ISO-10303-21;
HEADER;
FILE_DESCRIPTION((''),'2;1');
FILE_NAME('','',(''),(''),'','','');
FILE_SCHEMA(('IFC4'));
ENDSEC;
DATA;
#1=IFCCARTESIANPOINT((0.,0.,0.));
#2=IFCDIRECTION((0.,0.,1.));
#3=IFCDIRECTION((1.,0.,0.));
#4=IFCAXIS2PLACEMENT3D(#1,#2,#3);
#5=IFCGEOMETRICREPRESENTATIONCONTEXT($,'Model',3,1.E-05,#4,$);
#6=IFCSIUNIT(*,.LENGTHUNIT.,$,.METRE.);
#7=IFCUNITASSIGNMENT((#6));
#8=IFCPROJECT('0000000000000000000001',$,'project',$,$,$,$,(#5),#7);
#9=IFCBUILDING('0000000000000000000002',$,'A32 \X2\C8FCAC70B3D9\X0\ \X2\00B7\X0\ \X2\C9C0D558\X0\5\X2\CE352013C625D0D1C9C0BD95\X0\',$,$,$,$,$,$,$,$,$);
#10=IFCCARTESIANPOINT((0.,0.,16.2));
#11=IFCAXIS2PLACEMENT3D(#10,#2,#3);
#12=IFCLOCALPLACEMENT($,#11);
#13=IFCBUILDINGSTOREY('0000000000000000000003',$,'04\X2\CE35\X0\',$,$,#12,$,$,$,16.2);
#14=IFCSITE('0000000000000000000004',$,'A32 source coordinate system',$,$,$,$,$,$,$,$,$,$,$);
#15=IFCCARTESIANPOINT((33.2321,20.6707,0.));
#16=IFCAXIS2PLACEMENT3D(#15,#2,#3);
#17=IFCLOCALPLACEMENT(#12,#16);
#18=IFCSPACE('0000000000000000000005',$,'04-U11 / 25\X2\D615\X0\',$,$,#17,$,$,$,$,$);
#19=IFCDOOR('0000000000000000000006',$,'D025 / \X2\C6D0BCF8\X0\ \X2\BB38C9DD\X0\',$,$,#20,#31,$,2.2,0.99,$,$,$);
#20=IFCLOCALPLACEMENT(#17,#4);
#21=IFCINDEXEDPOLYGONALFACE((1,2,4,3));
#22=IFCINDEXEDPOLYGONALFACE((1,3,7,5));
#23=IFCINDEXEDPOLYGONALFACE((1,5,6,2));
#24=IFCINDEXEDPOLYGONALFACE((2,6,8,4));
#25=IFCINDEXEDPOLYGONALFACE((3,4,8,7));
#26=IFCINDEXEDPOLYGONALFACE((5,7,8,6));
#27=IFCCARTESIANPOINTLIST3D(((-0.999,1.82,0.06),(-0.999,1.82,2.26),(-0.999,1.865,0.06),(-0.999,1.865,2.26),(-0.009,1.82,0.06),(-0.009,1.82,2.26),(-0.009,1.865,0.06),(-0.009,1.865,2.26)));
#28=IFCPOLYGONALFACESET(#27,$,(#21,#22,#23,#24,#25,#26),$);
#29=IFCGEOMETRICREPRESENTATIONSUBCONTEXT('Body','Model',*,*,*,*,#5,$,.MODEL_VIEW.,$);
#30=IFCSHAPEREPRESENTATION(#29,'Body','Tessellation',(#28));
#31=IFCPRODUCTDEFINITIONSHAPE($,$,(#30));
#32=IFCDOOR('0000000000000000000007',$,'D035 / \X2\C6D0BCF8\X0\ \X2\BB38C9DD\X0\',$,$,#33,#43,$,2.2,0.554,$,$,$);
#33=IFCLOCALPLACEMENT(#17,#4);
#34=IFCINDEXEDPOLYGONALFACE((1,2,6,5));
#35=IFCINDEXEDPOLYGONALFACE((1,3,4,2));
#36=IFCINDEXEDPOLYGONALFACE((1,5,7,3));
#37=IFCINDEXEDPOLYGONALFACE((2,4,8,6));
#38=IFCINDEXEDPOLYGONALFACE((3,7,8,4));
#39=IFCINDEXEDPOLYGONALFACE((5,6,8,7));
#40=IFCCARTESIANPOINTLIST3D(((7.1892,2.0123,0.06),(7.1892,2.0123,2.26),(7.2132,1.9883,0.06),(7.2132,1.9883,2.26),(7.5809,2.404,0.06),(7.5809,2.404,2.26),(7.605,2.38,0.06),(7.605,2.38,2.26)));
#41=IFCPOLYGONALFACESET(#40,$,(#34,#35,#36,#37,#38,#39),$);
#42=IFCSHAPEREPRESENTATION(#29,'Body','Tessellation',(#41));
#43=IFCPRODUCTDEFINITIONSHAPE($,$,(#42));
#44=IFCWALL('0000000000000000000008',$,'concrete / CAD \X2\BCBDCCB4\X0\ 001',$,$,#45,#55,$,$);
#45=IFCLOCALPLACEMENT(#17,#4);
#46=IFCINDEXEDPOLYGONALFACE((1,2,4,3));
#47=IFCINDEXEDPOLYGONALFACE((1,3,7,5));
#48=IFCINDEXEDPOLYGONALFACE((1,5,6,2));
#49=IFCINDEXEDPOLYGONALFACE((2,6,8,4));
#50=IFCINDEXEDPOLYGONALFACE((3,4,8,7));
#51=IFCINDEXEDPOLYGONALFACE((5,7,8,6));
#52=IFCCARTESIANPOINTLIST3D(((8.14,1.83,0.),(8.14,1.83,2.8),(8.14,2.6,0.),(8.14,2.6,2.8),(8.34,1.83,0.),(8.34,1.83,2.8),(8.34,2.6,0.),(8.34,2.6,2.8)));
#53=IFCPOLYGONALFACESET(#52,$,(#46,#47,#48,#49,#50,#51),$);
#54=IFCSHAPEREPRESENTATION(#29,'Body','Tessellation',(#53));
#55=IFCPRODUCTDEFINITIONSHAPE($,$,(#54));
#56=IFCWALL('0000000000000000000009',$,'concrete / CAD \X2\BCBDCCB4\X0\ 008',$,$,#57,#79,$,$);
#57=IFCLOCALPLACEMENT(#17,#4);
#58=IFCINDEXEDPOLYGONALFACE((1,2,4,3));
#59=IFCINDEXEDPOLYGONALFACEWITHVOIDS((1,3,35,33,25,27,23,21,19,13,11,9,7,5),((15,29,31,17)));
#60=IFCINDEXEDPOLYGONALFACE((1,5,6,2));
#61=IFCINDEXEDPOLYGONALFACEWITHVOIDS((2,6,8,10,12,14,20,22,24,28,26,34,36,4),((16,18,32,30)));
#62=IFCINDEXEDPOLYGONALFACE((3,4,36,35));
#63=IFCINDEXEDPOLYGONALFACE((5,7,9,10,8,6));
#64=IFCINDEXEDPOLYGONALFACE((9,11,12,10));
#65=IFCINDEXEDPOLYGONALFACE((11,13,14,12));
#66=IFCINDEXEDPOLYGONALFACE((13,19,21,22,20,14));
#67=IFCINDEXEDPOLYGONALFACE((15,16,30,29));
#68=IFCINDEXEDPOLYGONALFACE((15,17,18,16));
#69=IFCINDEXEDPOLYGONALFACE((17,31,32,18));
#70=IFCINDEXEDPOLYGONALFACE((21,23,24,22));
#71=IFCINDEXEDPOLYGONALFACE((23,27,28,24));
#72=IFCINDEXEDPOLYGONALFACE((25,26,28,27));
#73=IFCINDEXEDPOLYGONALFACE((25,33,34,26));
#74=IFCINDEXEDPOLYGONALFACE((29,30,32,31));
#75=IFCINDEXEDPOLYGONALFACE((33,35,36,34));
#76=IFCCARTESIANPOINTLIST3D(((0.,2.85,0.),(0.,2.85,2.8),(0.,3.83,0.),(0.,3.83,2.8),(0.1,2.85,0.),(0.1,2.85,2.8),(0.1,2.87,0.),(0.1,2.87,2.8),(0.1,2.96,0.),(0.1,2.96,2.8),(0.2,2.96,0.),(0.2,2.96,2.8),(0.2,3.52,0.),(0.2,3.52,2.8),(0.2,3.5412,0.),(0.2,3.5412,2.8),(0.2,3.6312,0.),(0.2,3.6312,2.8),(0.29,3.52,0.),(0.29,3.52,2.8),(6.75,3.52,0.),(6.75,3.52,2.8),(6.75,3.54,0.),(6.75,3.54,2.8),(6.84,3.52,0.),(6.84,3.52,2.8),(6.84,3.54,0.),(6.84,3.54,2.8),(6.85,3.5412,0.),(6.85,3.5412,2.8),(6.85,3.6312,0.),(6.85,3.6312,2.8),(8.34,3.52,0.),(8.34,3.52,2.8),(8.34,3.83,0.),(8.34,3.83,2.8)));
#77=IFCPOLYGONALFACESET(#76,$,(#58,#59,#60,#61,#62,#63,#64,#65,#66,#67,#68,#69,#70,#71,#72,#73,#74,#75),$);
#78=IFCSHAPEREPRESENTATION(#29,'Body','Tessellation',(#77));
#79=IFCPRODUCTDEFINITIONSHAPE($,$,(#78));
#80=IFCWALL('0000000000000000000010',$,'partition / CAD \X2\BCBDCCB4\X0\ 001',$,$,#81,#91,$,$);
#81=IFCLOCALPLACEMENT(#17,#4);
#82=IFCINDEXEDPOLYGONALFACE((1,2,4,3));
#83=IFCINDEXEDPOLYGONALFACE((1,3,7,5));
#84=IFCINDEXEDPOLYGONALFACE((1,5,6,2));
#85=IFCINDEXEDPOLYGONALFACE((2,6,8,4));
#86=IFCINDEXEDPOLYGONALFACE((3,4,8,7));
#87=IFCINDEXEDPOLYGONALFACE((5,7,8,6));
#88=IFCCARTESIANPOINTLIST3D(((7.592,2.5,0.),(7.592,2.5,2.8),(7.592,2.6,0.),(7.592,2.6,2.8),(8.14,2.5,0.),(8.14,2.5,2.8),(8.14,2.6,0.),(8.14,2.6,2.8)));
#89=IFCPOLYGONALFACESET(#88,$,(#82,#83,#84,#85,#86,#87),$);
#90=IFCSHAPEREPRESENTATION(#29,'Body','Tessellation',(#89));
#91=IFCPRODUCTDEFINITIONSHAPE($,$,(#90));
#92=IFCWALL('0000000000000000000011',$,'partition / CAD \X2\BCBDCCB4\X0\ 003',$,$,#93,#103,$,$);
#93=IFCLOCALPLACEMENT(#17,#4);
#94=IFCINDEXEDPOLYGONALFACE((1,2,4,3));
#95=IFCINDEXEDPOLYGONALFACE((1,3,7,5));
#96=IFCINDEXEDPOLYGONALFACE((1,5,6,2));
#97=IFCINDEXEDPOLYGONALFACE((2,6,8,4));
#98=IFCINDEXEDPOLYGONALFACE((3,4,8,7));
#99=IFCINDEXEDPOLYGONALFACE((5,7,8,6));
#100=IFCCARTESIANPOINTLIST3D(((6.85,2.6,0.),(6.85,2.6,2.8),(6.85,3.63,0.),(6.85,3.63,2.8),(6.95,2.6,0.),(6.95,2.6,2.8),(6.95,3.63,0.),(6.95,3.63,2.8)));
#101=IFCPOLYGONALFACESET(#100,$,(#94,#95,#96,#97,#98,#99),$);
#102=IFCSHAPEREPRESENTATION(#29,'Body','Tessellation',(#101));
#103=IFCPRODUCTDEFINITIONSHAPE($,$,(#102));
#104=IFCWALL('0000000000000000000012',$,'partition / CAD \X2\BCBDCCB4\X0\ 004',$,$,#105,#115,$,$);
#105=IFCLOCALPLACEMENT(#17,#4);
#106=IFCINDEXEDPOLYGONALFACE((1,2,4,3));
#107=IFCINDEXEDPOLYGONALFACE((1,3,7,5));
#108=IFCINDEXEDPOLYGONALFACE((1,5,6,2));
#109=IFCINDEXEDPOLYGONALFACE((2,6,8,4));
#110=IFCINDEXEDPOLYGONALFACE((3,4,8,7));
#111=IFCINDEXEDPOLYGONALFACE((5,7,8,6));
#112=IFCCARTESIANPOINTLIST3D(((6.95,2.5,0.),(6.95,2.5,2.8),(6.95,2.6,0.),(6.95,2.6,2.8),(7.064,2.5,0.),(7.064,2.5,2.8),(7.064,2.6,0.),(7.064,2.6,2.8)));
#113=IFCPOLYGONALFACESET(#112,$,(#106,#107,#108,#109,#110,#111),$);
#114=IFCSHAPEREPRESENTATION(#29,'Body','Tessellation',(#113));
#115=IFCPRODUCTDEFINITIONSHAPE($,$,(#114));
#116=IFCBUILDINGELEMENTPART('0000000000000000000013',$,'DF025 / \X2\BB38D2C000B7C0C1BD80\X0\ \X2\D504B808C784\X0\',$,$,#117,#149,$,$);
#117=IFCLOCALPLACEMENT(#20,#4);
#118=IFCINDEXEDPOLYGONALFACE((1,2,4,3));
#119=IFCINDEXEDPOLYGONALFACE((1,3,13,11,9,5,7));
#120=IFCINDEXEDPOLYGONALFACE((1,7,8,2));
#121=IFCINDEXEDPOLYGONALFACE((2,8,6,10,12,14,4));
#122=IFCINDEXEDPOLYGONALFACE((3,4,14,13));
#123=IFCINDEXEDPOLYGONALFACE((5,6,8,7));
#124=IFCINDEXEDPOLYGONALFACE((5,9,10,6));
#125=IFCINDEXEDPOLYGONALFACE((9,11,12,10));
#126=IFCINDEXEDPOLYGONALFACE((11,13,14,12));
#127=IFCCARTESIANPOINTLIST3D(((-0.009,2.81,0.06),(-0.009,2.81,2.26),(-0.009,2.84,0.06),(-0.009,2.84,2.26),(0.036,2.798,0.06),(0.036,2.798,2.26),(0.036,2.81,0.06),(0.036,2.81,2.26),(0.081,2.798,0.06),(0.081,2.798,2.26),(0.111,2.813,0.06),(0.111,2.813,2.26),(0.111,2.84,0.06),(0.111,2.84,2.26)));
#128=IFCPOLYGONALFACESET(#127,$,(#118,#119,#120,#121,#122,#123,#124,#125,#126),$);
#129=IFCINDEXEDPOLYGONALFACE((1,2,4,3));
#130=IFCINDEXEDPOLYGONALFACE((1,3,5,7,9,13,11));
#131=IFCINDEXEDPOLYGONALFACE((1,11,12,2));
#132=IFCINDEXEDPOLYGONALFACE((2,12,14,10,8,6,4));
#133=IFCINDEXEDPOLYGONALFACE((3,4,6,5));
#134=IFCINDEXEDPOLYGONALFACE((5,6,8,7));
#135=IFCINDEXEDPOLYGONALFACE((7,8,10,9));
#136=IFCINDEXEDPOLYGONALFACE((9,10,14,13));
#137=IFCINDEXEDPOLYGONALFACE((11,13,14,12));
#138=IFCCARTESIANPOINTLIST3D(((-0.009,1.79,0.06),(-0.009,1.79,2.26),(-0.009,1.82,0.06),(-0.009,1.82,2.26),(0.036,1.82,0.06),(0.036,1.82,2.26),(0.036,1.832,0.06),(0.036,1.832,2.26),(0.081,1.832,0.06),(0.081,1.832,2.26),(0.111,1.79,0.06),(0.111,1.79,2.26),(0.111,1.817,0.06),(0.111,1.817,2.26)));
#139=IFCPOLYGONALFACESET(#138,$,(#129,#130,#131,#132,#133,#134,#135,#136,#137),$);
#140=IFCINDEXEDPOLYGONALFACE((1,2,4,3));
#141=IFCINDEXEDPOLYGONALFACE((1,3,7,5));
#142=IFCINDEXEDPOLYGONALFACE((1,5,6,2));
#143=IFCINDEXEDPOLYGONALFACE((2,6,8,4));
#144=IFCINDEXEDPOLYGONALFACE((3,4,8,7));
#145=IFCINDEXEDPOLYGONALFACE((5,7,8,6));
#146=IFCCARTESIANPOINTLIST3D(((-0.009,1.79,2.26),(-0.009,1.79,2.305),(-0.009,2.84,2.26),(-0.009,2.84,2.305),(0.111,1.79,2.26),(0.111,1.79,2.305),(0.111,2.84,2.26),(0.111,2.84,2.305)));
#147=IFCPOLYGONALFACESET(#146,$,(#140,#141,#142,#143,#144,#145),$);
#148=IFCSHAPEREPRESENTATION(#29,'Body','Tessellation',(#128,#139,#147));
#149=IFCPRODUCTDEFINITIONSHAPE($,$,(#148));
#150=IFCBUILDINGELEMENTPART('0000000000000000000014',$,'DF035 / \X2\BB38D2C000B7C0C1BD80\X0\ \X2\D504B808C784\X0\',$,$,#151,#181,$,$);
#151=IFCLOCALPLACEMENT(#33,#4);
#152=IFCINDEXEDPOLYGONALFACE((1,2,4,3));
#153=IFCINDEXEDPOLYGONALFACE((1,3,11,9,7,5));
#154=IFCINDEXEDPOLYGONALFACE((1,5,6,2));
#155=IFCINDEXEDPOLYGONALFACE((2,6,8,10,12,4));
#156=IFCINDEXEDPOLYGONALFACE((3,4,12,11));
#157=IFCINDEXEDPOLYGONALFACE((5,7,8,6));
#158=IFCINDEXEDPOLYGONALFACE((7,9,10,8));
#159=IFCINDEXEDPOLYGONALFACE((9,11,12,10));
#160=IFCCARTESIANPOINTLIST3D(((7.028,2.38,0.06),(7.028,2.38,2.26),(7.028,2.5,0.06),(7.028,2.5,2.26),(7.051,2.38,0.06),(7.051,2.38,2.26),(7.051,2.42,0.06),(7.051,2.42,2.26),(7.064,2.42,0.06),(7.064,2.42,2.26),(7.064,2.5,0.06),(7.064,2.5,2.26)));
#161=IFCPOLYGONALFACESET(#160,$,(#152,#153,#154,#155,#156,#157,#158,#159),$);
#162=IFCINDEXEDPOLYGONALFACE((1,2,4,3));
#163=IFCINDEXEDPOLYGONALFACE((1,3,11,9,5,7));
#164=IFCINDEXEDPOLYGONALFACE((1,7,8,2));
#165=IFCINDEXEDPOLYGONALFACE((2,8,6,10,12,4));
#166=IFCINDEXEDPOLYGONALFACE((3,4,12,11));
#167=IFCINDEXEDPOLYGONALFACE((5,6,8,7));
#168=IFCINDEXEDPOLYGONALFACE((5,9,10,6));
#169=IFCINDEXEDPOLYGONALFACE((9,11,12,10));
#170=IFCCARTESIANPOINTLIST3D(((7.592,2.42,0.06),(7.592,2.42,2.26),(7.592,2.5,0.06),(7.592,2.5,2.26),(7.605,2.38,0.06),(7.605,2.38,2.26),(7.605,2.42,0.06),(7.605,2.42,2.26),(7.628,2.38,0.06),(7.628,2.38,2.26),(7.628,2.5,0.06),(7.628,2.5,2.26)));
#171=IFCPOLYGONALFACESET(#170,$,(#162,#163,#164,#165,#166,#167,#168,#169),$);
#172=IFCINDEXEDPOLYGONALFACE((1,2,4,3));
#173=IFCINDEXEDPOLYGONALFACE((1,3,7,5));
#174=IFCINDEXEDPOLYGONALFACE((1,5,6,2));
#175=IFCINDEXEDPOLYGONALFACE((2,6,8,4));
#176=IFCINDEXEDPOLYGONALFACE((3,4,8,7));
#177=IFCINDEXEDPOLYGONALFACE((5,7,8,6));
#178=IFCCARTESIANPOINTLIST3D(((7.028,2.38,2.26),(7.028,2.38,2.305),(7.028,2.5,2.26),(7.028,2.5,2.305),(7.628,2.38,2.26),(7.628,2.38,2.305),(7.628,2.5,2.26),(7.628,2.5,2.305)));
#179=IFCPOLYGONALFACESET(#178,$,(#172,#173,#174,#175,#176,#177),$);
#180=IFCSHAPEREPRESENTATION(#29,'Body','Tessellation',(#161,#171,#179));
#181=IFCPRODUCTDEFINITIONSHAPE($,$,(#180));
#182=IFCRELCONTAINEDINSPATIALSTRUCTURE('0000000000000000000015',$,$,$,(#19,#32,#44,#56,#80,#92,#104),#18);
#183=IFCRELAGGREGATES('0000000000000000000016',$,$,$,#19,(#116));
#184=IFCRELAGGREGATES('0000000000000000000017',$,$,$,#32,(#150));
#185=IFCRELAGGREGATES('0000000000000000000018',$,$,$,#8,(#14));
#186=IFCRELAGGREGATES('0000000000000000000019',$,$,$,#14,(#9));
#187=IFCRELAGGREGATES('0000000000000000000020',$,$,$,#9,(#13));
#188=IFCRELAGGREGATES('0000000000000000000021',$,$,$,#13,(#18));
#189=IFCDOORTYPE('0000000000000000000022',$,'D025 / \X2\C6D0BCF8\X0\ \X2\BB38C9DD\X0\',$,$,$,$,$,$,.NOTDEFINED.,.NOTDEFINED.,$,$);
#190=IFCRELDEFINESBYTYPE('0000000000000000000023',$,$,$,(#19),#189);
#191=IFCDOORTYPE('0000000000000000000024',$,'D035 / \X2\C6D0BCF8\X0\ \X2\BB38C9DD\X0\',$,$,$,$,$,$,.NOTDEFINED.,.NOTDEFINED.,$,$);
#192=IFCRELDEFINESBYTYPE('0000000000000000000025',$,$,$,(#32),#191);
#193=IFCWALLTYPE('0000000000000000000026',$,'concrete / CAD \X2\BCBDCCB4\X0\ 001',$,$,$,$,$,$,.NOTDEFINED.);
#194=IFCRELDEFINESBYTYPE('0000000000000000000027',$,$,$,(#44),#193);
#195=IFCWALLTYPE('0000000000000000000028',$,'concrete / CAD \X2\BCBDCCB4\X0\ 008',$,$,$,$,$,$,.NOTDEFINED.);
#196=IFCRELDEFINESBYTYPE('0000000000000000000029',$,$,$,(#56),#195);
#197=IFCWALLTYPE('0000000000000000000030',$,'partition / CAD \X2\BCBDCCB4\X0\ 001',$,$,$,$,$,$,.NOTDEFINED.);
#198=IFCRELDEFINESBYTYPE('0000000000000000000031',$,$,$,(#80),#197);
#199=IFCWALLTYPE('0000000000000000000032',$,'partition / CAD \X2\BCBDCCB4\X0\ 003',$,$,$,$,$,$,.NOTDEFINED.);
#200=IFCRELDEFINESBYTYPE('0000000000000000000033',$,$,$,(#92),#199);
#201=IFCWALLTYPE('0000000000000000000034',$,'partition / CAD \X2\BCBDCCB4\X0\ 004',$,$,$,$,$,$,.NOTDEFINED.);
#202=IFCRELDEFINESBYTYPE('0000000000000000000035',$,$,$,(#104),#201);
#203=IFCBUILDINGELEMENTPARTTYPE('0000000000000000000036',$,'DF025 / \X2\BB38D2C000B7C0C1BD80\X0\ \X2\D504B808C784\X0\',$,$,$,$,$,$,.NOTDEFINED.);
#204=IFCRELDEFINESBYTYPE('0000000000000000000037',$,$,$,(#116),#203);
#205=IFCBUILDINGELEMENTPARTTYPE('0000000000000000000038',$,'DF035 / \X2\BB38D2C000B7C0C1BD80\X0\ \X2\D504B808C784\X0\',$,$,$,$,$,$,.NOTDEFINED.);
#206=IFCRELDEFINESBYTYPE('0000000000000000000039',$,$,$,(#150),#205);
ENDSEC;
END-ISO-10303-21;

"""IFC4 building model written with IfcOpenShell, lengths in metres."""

from ifc_helpers import new_model, si_unit, frame, origin, origin_with_axes, place, context, subcontext, project, spatial, polyline, outline, extrude, source, transform, mapped, type_object, type_shapes, element, aggregate, save


model = new_model("IFC4")

# Units and contexts
model_context = context("Model", 3, precision=1e-05, world=origin_with_axes())
body_context = subcontext(model_context, "Body", "Model", "MODEL_VIEW")
ifc_project = project(units=[si_unit("LENGTHUNIT", "METRE")], contexts=[model_context])

# Site, building, storey, space
storey_placement = place(None, frame((0.0, 0.0, 16.2), z_axis=(0.0, 0.0, 1.0), x_axis=(1.0, 0.0, 0.0)))
space_placement = place(storey_placement, frame((33.2321, 20.6707, 0.0), z_axis=(0.0, 0.0, 1.0), x_axis=(1.0, 0.0, 0.0)))
site = spatial("IfcSite", under=ifc_project, Name="A32 source coordinate system")
building = spatial("IfcBuilding", under=site, Name="A32 주거동 · 지하5층–옥탑지붕")
storey = spatial("IfcBuildingStorey", under=building, at=storey_placement, Name="04층", Elevation=16.2)
space = spatial("IfcSpace", under=storey, at=space_placement, Name="04-U11 / 25형")

# Doors
door_type_1 = type_object("IfcDoorType", Name="D025 / 원본 문짝", OperationType="NOTDEFINED", PredefinedType="NOTDEFINED")
shared_shape_1 = source(origin(), body_context, "Body", "SweptSolid", [
    extrude(outline(polyline([(-0.009, 1.82), (-0.999, 1.82), (-0.999, 1.865), (-0.009, 1.865), (-0.009, 1.82)])), frame((0.0, 0.0, 0.06)), (0.0, 0.0, 1.0), 2.2),
])
type_shapes(door_type_1, [shared_shape_1])
door_1_placement = place(space_placement, origin_with_axes())
door_1 = element("IfcDoor", 1, at=door_1_placement, inside=space, type_object=door_type_1, Name="D025 / 원본 문짝", OverallHeight=2.2, OverallWidth=0.99, context=body_context, shape_type="MappedRepresentation", body=[
    mapped(shared_shape_1, transform((0.0, 0.0, 0.0), scale=1.0)),
])
door_type_2 = type_object("IfcDoorType", Name="D035 / 원본 문짝", OperationType="NOTDEFINED", PredefinedType="NOTDEFINED")
shared_shape_2 = source(origin(), body_context, "Body", "SweptSolid", [
    extrude(outline(polyline([(7.605, 2.38), (7.2132, 1.9883), (7.1892, 2.0123), (7.5809, 2.404), (7.605, 2.38)])), frame((0.0, 0.0, 0.06)), (0.0, 0.0, 1.0), 2.2),
])
type_shapes(door_type_2, [shared_shape_2])
door_2_placement = place(space_placement, origin_with_axes())
door_2 = element("IfcDoor", 2, at=door_2_placement, inside=space, type_object=door_type_2, Name="D035 / 원본 문짝", OverallHeight=2.2, OverallWidth=0.554, context=body_context, shape_type="MappedRepresentation", body=[
    mapped(shared_shape_2, transform((0.0, 0.0, 0.0), scale=1.0)),
])

# Walls
wall_type_1 = type_object("IfcWallType", Name="concrete / CAD 벽체 001", PredefinedType="NOTDEFINED")
shared_shape_3 = source(origin(), body_context, "Body", "SweptSolid", [
    extrude(outline(polyline([(8.34, 1.83), (8.14, 1.83), (8.14, 2.6), (8.34, 2.6), (8.34, 1.83)])), origin(), (0.0, 0.0, 1.0), 2.8),
])
type_shapes(wall_type_1, [shared_shape_3])
wall_1_placement = place(space_placement, origin_with_axes())
element("IfcWall", 3, at=wall_1_placement, inside=space, type_object=wall_type_1, Name="concrete / CAD 벽체 001", context=body_context, shape_type="MappedRepresentation", body=[
    mapped(shared_shape_3, transform((0.0, 0.0, 0.0), scale=1.0)),
])
wall_type_2 = type_object("IfcWallType", Name="concrete / CAD 벽체 008", PredefinedType="NOTDEFINED")
shared_shape_4 = source(origin(), body_context, "Body", "SweptSolid", [
    extrude(outline(polyline([(0.0, 3.83), (8.34, 3.83), (8.34, 3.52), (6.84, 3.52), (6.84, 3.54), (6.75, 3.54), (6.75, 3.52), (0.29, 3.52), (0.2, 3.52), (0.2, 2.96), (0.1, 2.96), (0.1, 2.87), (0.1, 2.85), (0.0, 2.85), (0.0, 3.83)]), holes=[polyline([(6.85, 3.5412), (6.85, 3.6312), (0.2, 3.6312), (0.2, 3.5412), (6.85, 3.5412)])]), origin(), (0.0, 0.0, 1.0), 2.8),
])
type_shapes(wall_type_2, [shared_shape_4])
wall_2_placement = place(space_placement, origin_with_axes())
element("IfcWall", 4, at=wall_2_placement, inside=space, type_object=wall_type_2, Name="concrete / CAD 벽체 008", context=body_context, shape_type="MappedRepresentation", body=[
    mapped(shared_shape_4, transform((0.0, 0.0, 0.0), scale=1.0)),
])
wall_type_3 = type_object("IfcWallType", Name="partition / CAD 벽체 001", PredefinedType="NOTDEFINED")
shared_shape_5 = source(origin(), body_context, "Body", "SweptSolid", [
    extrude(outline(polyline([(8.14, 2.6), (8.14, 2.5), (7.592, 2.5), (7.592, 2.6), (8.14, 2.6)])), origin(), (0.0, 0.0, 1.0), 2.8),
])
type_shapes(wall_type_3, [shared_shape_5])
wall_3_placement = place(space_placement, origin_with_axes())
element("IfcWall", 5, at=wall_3_placement, inside=space, type_object=wall_type_3, Name="partition / CAD 벽체 001", context=body_context, shape_type="MappedRepresentation", body=[
    mapped(shared_shape_5, transform((0.0, 0.0, 0.0), scale=1.0)),
])
wall_type_4 = type_object("IfcWallType", Name="partition / CAD 벽체 003", PredefinedType="NOTDEFINED")
shared_shape_6 = source(origin(), body_context, "Body", "SweptSolid", [
    extrude(outline(polyline([(6.85, 2.6), (6.85, 3.63), (6.95, 3.63), (6.95, 2.6), (6.85, 2.6)])), origin(), (0.0, 0.0, 1.0), 2.8),
])
type_shapes(wall_type_4, [shared_shape_6])
wall_4_placement = place(space_placement, origin_with_axes())
element("IfcWall", 6, at=wall_4_placement, inside=space, type_object=wall_type_4, Name="partition / CAD 벽체 003", context=body_context, shape_type="MappedRepresentation", body=[
    mapped(shared_shape_6, transform((0.0, 0.0, 0.0), scale=1.0)),
])
wall_type_5 = type_object("IfcWallType", Name="partition / CAD 벽체 004", PredefinedType="NOTDEFINED")
shared_shape_7 = source(origin(), body_context, "Body", "SweptSolid", [
    extrude(outline(polyline([(6.95, 2.5), (6.95, 2.6), (7.064, 2.6), (7.064, 2.5), (6.95, 2.5)])), origin(), (0.0, 0.0, 1.0), 2.8),
])
type_shapes(wall_type_5, [shared_shape_7])
wall_5_placement = place(space_placement, origin_with_axes())
element("IfcWall", 7, at=wall_5_placement, inside=space, type_object=wall_type_5, Name="partition / CAD 벽체 004", context=body_context, shape_type="MappedRepresentation", body=[
    mapped(shared_shape_7, transform((0.0, 0.0, 0.0), scale=1.0)),
])

# Building element parts
building_element_part_type_1 = type_object("IfcBuildingElementPartType", Name="DF025 / 문틀·상부 프레임", PredefinedType="NOTDEFINED")
shared_shape_8 = source(origin(), body_context, "Body", "SweptSolid", [
    extrude(outline(polyline([(0.111, 2.84), (0.111, 2.813), (0.081, 2.798), (0.036, 2.798), (0.036, 2.81), (-0.009, 2.81), (-0.009, 2.84), (0.111, 2.84)])), frame((0.0, 0.0, 0.06)), (0.0, 0.0, 1.0), 2.2),
    extrude(outline(polyline([(-0.009, 1.82), (0.036, 1.82), (0.036, 1.832), (0.081, 1.832), (0.111, 1.817), (0.111, 1.79), (-0.009, 1.79), (-0.009, 1.82)])), frame((0.0, 0.0, 0.06)), (0.0, 0.0, 1.0), 2.2),
    extrude(outline(polyline([(-0.009, 1.79), (-0.009, 2.84), (0.111, 2.84), (0.111, 1.79), (-0.009, 1.79)])), frame((0.0, 0.0, 2.26)), (0.0, 0.0, 1.0), 0.045),
])
type_shapes(building_element_part_type_1, [shared_shape_8])
building_element_part_1_placement = place(door_1_placement, origin_with_axes())
building_element_part_1 = element("IfcBuildingElementPart", 8, at=building_element_part_1_placement, type_object=building_element_part_type_1, Name="DF025 / 문틀·상부 프레임", context=body_context, shape_type="MappedRepresentation", body=[
    mapped(shared_shape_8, transform((0.0, 0.0, 0.0), scale=1.0)),
])
aggregate(door_1, [building_element_part_1])
building_element_part_type_2 = type_object("IfcBuildingElementPartType", Name="DF035 / 문틀·상부 프레임", PredefinedType="NOTDEFINED")
shared_shape_9 = source(origin(), body_context, "Body", "SweptSolid", [
    extrude(outline(polyline([(7.064, 2.5), (7.064, 2.42), (7.051, 2.42), (7.051, 2.38), (7.028, 2.38), (7.028, 2.5), (7.064, 2.5)])), frame((0.0, 0.0, 0.06)), (0.0, 0.0, 1.0), 2.2),
    extrude(outline(polyline([(7.628, 2.38), (7.605, 2.38), (7.605, 2.42), (7.592, 2.42), (7.592, 2.5), (7.628, 2.5), (7.628, 2.38)])), frame((0.0, 0.0, 0.06)), (0.0, 0.0, 1.0), 2.2),
    extrude(outline(polyline([(7.028, 2.38), (7.028, 2.5), (7.628, 2.5), (7.628, 2.38), (7.028, 2.38)])), frame((0.0, 0.0, 2.26)), (0.0, 0.0, 1.0), 0.045),
])
type_shapes(building_element_part_type_2, [shared_shape_9])
building_element_part_2_placement = place(door_2_placement, origin_with_axes())
building_element_part_2 = element("IfcBuildingElementPart", 9, at=building_element_part_2_placement, type_object=building_element_part_type_2, Name="DF035 / 문틀·상부 프레임", context=body_context, shape_type="MappedRepresentation", body=[
    mapped(shared_shape_9, transform((0.0, 0.0, 0.0), scale=1.0)),
])
aggregate(door_2, [building_element_part_2])

save(model, "model.ifc")
